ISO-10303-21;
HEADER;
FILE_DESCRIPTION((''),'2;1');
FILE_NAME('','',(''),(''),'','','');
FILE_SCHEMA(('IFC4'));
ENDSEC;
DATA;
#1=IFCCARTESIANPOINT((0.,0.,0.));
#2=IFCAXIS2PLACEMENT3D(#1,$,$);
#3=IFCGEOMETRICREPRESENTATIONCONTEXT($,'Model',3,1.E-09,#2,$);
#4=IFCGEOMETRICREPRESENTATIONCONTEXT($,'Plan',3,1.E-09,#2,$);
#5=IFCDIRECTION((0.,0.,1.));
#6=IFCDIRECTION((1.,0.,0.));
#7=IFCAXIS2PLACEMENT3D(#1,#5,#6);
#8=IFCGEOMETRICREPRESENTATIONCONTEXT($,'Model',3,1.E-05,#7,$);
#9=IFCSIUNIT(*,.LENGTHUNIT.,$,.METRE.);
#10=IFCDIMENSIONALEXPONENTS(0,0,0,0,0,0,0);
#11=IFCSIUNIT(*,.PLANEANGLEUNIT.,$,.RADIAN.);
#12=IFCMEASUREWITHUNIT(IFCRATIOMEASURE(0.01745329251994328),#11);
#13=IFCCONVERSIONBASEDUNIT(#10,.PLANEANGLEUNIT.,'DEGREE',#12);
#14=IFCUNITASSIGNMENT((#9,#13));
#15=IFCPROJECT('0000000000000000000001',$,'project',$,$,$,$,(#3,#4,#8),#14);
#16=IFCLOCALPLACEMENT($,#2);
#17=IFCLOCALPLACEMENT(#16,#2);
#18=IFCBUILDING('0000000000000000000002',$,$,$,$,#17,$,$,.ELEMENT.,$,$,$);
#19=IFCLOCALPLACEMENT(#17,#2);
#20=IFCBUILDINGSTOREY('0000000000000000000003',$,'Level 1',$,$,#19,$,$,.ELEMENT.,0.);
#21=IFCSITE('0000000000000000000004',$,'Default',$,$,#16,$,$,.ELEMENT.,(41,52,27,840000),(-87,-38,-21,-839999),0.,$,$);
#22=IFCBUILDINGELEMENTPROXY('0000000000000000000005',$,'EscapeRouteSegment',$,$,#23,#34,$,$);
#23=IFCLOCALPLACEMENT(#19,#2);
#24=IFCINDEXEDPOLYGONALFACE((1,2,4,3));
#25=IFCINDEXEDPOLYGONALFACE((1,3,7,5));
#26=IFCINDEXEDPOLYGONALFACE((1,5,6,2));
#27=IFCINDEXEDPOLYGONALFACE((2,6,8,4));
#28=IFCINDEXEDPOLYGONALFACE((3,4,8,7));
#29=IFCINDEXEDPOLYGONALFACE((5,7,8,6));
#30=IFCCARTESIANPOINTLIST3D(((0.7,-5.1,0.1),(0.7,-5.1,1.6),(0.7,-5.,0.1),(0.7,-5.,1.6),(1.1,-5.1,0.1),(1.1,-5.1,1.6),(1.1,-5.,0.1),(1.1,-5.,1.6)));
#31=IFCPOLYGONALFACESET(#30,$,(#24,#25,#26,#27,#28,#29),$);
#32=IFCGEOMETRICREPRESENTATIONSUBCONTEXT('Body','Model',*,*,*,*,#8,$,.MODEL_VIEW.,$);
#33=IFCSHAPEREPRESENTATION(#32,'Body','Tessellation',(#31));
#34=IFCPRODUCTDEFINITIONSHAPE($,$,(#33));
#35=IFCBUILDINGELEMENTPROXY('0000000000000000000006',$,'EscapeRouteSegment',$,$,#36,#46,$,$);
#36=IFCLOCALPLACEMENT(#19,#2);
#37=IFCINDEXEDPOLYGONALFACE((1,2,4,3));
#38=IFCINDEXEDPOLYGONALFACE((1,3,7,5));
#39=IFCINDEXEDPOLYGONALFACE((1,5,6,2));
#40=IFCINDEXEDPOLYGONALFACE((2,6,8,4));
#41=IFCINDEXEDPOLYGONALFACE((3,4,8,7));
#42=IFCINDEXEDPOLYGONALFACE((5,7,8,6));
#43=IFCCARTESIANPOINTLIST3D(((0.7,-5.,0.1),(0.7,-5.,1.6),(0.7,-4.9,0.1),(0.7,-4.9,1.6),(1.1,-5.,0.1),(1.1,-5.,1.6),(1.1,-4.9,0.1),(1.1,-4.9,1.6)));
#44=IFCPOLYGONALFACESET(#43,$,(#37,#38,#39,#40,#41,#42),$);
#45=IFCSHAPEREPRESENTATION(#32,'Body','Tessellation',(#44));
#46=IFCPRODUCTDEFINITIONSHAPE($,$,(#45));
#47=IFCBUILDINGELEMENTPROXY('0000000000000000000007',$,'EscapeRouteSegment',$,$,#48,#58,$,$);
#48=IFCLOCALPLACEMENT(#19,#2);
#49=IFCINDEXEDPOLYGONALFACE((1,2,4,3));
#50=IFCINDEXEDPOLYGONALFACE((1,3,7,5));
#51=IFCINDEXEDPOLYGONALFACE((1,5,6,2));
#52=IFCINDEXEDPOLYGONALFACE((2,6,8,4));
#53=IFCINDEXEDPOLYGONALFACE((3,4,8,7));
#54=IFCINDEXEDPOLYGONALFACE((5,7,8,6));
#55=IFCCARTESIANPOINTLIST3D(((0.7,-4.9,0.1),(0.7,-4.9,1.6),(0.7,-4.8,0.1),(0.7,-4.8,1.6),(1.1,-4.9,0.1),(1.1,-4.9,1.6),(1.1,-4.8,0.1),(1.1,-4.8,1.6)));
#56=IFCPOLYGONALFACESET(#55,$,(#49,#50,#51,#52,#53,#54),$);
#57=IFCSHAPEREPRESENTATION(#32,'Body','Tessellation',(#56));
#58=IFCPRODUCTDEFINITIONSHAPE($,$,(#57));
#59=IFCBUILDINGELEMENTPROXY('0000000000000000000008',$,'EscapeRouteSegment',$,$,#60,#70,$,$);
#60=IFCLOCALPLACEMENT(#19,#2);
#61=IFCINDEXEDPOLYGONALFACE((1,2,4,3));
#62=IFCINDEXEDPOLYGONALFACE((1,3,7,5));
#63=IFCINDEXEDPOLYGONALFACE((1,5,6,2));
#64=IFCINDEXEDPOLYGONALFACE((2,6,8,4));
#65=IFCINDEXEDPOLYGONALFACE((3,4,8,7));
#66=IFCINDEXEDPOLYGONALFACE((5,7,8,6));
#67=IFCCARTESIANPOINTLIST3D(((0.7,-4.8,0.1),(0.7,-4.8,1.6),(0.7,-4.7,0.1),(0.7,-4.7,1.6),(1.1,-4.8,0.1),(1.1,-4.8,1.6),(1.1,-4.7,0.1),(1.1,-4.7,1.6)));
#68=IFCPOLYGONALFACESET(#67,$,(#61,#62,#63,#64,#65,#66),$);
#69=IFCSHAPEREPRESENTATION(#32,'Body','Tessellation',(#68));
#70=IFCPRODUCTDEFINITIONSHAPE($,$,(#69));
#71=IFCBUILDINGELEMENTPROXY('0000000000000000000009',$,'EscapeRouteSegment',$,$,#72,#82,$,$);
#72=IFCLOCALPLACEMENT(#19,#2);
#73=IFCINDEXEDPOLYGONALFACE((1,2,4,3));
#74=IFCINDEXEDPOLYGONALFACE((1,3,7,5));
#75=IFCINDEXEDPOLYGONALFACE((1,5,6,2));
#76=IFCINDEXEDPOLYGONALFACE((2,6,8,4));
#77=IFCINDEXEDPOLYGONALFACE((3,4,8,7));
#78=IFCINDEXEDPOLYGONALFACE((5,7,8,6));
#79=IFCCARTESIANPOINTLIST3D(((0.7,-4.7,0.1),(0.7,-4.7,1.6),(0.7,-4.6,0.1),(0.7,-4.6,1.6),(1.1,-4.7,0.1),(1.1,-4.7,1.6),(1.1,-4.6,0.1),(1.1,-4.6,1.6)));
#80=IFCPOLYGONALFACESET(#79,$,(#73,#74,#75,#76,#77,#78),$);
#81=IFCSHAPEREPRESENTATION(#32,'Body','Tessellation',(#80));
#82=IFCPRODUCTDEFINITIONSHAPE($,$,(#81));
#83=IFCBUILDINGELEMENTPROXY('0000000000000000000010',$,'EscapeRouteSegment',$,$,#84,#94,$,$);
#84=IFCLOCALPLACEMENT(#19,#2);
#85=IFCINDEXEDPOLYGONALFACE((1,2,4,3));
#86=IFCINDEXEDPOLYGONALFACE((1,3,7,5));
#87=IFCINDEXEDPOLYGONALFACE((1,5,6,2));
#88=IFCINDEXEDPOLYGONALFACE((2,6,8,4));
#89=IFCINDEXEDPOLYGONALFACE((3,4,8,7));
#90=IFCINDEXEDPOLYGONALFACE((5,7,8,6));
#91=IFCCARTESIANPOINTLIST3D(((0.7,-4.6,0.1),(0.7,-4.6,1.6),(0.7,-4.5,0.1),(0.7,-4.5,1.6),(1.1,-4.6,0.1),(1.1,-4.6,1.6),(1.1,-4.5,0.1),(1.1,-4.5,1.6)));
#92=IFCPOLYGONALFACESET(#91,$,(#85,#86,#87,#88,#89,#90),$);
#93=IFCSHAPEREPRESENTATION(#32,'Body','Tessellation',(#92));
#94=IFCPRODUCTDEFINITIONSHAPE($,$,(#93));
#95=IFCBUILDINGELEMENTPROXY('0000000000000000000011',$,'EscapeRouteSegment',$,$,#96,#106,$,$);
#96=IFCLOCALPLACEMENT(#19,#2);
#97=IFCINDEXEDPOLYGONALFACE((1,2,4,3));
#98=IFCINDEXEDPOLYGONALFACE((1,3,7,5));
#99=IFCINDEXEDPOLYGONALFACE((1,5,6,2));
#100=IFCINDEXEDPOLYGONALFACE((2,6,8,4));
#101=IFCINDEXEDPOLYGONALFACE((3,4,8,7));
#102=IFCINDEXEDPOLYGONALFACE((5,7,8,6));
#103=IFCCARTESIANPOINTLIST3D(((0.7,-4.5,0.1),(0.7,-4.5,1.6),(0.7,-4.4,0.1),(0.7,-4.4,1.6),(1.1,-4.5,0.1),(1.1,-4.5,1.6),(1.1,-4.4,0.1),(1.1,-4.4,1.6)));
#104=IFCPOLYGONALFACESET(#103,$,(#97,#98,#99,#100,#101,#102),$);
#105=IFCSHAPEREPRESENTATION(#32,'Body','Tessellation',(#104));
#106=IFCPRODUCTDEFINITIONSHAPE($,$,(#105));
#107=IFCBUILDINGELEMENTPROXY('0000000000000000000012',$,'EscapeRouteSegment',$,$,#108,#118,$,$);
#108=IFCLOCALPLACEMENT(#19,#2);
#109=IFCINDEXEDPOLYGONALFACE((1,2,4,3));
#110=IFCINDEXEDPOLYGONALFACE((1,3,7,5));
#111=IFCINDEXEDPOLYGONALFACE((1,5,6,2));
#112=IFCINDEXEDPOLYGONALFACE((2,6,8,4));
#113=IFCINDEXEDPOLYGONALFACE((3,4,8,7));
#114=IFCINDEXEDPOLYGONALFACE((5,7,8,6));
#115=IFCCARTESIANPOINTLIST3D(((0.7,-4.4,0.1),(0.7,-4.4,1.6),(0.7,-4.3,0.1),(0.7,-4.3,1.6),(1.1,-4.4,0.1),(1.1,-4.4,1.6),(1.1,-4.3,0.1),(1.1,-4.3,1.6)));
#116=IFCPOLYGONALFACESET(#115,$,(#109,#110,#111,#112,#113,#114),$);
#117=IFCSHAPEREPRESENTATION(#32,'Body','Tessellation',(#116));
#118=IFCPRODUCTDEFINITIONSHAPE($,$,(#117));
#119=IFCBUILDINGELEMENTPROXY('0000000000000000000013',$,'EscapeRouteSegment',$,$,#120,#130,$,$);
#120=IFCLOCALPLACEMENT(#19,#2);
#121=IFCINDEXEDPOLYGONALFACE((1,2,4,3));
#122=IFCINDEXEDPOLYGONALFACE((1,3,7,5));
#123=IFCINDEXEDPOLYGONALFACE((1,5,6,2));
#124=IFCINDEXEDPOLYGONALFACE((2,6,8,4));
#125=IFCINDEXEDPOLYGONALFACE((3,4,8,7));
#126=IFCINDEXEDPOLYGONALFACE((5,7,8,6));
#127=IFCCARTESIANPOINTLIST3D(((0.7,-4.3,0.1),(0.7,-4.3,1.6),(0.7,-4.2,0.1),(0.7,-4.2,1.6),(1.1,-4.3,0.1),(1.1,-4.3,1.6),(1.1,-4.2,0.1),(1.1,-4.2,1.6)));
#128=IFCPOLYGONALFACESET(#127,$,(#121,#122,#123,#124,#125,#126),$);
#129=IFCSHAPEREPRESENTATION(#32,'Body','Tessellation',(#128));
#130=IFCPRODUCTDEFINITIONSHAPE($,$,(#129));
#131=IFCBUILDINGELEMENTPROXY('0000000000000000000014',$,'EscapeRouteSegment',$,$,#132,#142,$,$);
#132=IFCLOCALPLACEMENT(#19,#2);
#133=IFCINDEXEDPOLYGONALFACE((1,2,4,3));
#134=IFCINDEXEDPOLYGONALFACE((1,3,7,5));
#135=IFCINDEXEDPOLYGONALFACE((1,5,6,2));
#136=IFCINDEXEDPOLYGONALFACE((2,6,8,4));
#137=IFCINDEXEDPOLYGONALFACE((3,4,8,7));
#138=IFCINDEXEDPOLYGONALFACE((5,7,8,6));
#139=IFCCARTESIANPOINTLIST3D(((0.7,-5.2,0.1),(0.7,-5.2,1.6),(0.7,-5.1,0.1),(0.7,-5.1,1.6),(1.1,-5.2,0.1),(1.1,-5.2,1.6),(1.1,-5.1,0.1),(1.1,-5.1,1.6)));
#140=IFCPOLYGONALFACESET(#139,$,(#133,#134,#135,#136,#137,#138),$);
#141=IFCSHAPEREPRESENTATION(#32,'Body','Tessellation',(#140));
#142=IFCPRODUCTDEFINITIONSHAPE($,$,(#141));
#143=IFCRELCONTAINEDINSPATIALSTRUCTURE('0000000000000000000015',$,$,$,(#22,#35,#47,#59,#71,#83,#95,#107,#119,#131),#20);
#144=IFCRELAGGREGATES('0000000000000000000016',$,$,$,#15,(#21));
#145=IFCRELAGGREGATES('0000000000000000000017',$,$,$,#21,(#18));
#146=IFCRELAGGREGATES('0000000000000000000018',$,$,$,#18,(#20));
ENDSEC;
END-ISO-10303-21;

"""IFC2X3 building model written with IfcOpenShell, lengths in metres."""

from ifc_helpers import new_model, entity, si_unit, converted_unit, frame, origin, origin_with_axes, place, context, subcontext, project, spatial, polyline, outline, extrude, element, save


model = new_model("IFC2X3")

# Units and contexts
model_context_1 = context("Model", 3, precision=1e-09, world=origin())
plan_context = context("Plan", 3, precision=1e-09, world=origin())
model_context_2 = context("Model", 3, precision=1e-05, world=origin_with_axes())
body_context = subcontext(model_context_2, "Body", "Model", "MODEL_VIEW")
ifc_project = project(units=[si_unit("LENGTHUNIT", "METRE"), converted_unit("PLANEANGLEUNIT", "DEGREE", entity("IfcRatioMeasure", 0.01745329251994328), si_unit("PLANEANGLEUNIT", "RADIAN"), dimensions=[0, 0, 0, 0, 0, 0, 0])], contexts=[model_context_1, plan_context, model_context_2])

# Site, building, storey
site_placement = place(None, origin())
site = spatial("IfcSite", under=ifc_project, at=site_placement, Name="Default", CompositionType="ELEMENT", RefLatitude=(41, 52, 27, 840000), RefLongitude=(-87, -38, -21, -839999), RefElevation=0.0)
building_placement = place(site_placement, origin())
building = spatial("IfcBuilding", under=site, at=building_placement, CompositionType="ELEMENT")
storey_placement = place(building_placement, origin())
storey = spatial("IfcBuildingStorey", under=building, at=storey_placement, Name="Level 1", CompositionType="ELEMENT", Elevation=0.0)

# Building element proxies
for number, where, z_axis, x_axis, name in (
    (1, (0.9, -5.1, 0.1), (0.0, 0.0, 1.0), (0.0, 1.0, 0.0), "EscapeRouteSegment"),
    (2, (0.9, -5.0, 0.1), (0.0, 0.0, 1.0), (0.0, 1.0, 0.0), "EscapeRouteSegment"),
    (3, (0.9, -4.9, 0.1), (0.0, 0.0, 1.0), (0.0, 1.0, 0.0), "EscapeRouteSegment"),
):
    element("IfcBuildingElementProxy", number, at=place(storey_placement, frame(where, z_axis=z_axis, x_axis=x_axis)), inside=storey, Name=name, context=body_context, shape_type="SweptSolid", body=[
        extrude(outline(polyline([(0.0, -0.2), (0.0, 0.2), (0.1, 0.2), (0.1, -0.2), (0.0, -0.2)])), origin_with_axes(), (0.0, 0.0, 1.0), 1.5),
    ])
proxy_1_placement = place(storey_placement, frame((0.9, -4.8, 0.1), z_axis=(0.0, 0.0, 1.0), x_axis=(0.0, 1.0, 0.0)))
element("IfcBuildingElementProxy", 4, at=proxy_1_placement, inside=storey, Name="EscapeRouteSegment", context=body_context, shape_type="SweptSolid", body=[
    extrude(outline(polyline([(0.0, -0.2), (0.0, 0.2), (0.1, 0.2), (0.1, -0.2), (0.0, -0.2)])), origin_with_axes(), (0.0, 0.0, 1.0), 1.5),
])
for number, where, z_axis, x_axis, name in (
    (5, (0.9, -4.7, 0.1), (0.0, 0.0, 1.0), (0.0, 1.0, 0.0), "EscapeRouteSegment"),
    (6, (0.9, -4.6, 0.1), (0.0, 0.0, 1.0), (0.0, 1.0, 0.0), "EscapeRouteSegment"),
    (7, (0.9, -4.5, 0.1), (0.0, 0.0, 1.0), (0.0, 1.0, 0.0), "EscapeRouteSegment"),
    (8, (0.9, -4.4, 0.1), (0.0, 0.0, 1.0), (0.0, 1.0, 0.0), "EscapeRouteSegment"),
):
    element("IfcBuildingElementProxy", number, at=place(storey_placement, frame(where, z_axis=z_axis, x_axis=x_axis)), inside=storey, Name=name, context=body_context, shape_type="SweptSolid", body=[
        extrude(outline(polyline([(0.0, -0.2), (0.0, 0.2), (0.1, 0.2), (0.1, -0.2), (0.0, -0.2)])), origin_with_axes(), (0.0, 0.0, 1.0), 1.5),
    ])
proxy_2_placement = place(storey_placement, frame((0.9, -4.3, 0.1), z_axis=(0.0, 0.0, 1.0), x_axis=(0.0, 1.0, 0.0)))
element("IfcBuildingElementProxy", 9, at=proxy_2_placement, inside=storey, Name="EscapeRouteSegment", context=body_context, shape_type="SweptSolid", body=[
    extrude(outline(polyline([(0.0, -0.2), (0.0, 0.2), (0.1, 0.2), (0.1, -0.2), (0.0, -0.2)])), origin_with_axes(), (0.0, 0.0, 1.0), 1.5),
])
for number, where, z_axis, x_axis, name in (
    (10, (0.9, -5.2, 0.1), (0.0, 0.0, 1.0), (0.0, 1.0, 0.0), "EscapeRouteSegment"),
):
    element("IfcBuildingElementProxy", number, at=place(storey_placement, frame(where, z_axis=z_axis, x_axis=x_axis)), inside=storey, Name=name, context=body_context, shape_type="SweptSolid", body=[
        extrude(outline(polyline([(0.0, -0.2), (0.0, 0.2), (0.1, 0.2), (0.1, -0.2), (0.0, -0.2)])), origin_with_axes(), (0.0, 0.0, 1.0), 1.5),
    ])

save(model, "model.ifc")
